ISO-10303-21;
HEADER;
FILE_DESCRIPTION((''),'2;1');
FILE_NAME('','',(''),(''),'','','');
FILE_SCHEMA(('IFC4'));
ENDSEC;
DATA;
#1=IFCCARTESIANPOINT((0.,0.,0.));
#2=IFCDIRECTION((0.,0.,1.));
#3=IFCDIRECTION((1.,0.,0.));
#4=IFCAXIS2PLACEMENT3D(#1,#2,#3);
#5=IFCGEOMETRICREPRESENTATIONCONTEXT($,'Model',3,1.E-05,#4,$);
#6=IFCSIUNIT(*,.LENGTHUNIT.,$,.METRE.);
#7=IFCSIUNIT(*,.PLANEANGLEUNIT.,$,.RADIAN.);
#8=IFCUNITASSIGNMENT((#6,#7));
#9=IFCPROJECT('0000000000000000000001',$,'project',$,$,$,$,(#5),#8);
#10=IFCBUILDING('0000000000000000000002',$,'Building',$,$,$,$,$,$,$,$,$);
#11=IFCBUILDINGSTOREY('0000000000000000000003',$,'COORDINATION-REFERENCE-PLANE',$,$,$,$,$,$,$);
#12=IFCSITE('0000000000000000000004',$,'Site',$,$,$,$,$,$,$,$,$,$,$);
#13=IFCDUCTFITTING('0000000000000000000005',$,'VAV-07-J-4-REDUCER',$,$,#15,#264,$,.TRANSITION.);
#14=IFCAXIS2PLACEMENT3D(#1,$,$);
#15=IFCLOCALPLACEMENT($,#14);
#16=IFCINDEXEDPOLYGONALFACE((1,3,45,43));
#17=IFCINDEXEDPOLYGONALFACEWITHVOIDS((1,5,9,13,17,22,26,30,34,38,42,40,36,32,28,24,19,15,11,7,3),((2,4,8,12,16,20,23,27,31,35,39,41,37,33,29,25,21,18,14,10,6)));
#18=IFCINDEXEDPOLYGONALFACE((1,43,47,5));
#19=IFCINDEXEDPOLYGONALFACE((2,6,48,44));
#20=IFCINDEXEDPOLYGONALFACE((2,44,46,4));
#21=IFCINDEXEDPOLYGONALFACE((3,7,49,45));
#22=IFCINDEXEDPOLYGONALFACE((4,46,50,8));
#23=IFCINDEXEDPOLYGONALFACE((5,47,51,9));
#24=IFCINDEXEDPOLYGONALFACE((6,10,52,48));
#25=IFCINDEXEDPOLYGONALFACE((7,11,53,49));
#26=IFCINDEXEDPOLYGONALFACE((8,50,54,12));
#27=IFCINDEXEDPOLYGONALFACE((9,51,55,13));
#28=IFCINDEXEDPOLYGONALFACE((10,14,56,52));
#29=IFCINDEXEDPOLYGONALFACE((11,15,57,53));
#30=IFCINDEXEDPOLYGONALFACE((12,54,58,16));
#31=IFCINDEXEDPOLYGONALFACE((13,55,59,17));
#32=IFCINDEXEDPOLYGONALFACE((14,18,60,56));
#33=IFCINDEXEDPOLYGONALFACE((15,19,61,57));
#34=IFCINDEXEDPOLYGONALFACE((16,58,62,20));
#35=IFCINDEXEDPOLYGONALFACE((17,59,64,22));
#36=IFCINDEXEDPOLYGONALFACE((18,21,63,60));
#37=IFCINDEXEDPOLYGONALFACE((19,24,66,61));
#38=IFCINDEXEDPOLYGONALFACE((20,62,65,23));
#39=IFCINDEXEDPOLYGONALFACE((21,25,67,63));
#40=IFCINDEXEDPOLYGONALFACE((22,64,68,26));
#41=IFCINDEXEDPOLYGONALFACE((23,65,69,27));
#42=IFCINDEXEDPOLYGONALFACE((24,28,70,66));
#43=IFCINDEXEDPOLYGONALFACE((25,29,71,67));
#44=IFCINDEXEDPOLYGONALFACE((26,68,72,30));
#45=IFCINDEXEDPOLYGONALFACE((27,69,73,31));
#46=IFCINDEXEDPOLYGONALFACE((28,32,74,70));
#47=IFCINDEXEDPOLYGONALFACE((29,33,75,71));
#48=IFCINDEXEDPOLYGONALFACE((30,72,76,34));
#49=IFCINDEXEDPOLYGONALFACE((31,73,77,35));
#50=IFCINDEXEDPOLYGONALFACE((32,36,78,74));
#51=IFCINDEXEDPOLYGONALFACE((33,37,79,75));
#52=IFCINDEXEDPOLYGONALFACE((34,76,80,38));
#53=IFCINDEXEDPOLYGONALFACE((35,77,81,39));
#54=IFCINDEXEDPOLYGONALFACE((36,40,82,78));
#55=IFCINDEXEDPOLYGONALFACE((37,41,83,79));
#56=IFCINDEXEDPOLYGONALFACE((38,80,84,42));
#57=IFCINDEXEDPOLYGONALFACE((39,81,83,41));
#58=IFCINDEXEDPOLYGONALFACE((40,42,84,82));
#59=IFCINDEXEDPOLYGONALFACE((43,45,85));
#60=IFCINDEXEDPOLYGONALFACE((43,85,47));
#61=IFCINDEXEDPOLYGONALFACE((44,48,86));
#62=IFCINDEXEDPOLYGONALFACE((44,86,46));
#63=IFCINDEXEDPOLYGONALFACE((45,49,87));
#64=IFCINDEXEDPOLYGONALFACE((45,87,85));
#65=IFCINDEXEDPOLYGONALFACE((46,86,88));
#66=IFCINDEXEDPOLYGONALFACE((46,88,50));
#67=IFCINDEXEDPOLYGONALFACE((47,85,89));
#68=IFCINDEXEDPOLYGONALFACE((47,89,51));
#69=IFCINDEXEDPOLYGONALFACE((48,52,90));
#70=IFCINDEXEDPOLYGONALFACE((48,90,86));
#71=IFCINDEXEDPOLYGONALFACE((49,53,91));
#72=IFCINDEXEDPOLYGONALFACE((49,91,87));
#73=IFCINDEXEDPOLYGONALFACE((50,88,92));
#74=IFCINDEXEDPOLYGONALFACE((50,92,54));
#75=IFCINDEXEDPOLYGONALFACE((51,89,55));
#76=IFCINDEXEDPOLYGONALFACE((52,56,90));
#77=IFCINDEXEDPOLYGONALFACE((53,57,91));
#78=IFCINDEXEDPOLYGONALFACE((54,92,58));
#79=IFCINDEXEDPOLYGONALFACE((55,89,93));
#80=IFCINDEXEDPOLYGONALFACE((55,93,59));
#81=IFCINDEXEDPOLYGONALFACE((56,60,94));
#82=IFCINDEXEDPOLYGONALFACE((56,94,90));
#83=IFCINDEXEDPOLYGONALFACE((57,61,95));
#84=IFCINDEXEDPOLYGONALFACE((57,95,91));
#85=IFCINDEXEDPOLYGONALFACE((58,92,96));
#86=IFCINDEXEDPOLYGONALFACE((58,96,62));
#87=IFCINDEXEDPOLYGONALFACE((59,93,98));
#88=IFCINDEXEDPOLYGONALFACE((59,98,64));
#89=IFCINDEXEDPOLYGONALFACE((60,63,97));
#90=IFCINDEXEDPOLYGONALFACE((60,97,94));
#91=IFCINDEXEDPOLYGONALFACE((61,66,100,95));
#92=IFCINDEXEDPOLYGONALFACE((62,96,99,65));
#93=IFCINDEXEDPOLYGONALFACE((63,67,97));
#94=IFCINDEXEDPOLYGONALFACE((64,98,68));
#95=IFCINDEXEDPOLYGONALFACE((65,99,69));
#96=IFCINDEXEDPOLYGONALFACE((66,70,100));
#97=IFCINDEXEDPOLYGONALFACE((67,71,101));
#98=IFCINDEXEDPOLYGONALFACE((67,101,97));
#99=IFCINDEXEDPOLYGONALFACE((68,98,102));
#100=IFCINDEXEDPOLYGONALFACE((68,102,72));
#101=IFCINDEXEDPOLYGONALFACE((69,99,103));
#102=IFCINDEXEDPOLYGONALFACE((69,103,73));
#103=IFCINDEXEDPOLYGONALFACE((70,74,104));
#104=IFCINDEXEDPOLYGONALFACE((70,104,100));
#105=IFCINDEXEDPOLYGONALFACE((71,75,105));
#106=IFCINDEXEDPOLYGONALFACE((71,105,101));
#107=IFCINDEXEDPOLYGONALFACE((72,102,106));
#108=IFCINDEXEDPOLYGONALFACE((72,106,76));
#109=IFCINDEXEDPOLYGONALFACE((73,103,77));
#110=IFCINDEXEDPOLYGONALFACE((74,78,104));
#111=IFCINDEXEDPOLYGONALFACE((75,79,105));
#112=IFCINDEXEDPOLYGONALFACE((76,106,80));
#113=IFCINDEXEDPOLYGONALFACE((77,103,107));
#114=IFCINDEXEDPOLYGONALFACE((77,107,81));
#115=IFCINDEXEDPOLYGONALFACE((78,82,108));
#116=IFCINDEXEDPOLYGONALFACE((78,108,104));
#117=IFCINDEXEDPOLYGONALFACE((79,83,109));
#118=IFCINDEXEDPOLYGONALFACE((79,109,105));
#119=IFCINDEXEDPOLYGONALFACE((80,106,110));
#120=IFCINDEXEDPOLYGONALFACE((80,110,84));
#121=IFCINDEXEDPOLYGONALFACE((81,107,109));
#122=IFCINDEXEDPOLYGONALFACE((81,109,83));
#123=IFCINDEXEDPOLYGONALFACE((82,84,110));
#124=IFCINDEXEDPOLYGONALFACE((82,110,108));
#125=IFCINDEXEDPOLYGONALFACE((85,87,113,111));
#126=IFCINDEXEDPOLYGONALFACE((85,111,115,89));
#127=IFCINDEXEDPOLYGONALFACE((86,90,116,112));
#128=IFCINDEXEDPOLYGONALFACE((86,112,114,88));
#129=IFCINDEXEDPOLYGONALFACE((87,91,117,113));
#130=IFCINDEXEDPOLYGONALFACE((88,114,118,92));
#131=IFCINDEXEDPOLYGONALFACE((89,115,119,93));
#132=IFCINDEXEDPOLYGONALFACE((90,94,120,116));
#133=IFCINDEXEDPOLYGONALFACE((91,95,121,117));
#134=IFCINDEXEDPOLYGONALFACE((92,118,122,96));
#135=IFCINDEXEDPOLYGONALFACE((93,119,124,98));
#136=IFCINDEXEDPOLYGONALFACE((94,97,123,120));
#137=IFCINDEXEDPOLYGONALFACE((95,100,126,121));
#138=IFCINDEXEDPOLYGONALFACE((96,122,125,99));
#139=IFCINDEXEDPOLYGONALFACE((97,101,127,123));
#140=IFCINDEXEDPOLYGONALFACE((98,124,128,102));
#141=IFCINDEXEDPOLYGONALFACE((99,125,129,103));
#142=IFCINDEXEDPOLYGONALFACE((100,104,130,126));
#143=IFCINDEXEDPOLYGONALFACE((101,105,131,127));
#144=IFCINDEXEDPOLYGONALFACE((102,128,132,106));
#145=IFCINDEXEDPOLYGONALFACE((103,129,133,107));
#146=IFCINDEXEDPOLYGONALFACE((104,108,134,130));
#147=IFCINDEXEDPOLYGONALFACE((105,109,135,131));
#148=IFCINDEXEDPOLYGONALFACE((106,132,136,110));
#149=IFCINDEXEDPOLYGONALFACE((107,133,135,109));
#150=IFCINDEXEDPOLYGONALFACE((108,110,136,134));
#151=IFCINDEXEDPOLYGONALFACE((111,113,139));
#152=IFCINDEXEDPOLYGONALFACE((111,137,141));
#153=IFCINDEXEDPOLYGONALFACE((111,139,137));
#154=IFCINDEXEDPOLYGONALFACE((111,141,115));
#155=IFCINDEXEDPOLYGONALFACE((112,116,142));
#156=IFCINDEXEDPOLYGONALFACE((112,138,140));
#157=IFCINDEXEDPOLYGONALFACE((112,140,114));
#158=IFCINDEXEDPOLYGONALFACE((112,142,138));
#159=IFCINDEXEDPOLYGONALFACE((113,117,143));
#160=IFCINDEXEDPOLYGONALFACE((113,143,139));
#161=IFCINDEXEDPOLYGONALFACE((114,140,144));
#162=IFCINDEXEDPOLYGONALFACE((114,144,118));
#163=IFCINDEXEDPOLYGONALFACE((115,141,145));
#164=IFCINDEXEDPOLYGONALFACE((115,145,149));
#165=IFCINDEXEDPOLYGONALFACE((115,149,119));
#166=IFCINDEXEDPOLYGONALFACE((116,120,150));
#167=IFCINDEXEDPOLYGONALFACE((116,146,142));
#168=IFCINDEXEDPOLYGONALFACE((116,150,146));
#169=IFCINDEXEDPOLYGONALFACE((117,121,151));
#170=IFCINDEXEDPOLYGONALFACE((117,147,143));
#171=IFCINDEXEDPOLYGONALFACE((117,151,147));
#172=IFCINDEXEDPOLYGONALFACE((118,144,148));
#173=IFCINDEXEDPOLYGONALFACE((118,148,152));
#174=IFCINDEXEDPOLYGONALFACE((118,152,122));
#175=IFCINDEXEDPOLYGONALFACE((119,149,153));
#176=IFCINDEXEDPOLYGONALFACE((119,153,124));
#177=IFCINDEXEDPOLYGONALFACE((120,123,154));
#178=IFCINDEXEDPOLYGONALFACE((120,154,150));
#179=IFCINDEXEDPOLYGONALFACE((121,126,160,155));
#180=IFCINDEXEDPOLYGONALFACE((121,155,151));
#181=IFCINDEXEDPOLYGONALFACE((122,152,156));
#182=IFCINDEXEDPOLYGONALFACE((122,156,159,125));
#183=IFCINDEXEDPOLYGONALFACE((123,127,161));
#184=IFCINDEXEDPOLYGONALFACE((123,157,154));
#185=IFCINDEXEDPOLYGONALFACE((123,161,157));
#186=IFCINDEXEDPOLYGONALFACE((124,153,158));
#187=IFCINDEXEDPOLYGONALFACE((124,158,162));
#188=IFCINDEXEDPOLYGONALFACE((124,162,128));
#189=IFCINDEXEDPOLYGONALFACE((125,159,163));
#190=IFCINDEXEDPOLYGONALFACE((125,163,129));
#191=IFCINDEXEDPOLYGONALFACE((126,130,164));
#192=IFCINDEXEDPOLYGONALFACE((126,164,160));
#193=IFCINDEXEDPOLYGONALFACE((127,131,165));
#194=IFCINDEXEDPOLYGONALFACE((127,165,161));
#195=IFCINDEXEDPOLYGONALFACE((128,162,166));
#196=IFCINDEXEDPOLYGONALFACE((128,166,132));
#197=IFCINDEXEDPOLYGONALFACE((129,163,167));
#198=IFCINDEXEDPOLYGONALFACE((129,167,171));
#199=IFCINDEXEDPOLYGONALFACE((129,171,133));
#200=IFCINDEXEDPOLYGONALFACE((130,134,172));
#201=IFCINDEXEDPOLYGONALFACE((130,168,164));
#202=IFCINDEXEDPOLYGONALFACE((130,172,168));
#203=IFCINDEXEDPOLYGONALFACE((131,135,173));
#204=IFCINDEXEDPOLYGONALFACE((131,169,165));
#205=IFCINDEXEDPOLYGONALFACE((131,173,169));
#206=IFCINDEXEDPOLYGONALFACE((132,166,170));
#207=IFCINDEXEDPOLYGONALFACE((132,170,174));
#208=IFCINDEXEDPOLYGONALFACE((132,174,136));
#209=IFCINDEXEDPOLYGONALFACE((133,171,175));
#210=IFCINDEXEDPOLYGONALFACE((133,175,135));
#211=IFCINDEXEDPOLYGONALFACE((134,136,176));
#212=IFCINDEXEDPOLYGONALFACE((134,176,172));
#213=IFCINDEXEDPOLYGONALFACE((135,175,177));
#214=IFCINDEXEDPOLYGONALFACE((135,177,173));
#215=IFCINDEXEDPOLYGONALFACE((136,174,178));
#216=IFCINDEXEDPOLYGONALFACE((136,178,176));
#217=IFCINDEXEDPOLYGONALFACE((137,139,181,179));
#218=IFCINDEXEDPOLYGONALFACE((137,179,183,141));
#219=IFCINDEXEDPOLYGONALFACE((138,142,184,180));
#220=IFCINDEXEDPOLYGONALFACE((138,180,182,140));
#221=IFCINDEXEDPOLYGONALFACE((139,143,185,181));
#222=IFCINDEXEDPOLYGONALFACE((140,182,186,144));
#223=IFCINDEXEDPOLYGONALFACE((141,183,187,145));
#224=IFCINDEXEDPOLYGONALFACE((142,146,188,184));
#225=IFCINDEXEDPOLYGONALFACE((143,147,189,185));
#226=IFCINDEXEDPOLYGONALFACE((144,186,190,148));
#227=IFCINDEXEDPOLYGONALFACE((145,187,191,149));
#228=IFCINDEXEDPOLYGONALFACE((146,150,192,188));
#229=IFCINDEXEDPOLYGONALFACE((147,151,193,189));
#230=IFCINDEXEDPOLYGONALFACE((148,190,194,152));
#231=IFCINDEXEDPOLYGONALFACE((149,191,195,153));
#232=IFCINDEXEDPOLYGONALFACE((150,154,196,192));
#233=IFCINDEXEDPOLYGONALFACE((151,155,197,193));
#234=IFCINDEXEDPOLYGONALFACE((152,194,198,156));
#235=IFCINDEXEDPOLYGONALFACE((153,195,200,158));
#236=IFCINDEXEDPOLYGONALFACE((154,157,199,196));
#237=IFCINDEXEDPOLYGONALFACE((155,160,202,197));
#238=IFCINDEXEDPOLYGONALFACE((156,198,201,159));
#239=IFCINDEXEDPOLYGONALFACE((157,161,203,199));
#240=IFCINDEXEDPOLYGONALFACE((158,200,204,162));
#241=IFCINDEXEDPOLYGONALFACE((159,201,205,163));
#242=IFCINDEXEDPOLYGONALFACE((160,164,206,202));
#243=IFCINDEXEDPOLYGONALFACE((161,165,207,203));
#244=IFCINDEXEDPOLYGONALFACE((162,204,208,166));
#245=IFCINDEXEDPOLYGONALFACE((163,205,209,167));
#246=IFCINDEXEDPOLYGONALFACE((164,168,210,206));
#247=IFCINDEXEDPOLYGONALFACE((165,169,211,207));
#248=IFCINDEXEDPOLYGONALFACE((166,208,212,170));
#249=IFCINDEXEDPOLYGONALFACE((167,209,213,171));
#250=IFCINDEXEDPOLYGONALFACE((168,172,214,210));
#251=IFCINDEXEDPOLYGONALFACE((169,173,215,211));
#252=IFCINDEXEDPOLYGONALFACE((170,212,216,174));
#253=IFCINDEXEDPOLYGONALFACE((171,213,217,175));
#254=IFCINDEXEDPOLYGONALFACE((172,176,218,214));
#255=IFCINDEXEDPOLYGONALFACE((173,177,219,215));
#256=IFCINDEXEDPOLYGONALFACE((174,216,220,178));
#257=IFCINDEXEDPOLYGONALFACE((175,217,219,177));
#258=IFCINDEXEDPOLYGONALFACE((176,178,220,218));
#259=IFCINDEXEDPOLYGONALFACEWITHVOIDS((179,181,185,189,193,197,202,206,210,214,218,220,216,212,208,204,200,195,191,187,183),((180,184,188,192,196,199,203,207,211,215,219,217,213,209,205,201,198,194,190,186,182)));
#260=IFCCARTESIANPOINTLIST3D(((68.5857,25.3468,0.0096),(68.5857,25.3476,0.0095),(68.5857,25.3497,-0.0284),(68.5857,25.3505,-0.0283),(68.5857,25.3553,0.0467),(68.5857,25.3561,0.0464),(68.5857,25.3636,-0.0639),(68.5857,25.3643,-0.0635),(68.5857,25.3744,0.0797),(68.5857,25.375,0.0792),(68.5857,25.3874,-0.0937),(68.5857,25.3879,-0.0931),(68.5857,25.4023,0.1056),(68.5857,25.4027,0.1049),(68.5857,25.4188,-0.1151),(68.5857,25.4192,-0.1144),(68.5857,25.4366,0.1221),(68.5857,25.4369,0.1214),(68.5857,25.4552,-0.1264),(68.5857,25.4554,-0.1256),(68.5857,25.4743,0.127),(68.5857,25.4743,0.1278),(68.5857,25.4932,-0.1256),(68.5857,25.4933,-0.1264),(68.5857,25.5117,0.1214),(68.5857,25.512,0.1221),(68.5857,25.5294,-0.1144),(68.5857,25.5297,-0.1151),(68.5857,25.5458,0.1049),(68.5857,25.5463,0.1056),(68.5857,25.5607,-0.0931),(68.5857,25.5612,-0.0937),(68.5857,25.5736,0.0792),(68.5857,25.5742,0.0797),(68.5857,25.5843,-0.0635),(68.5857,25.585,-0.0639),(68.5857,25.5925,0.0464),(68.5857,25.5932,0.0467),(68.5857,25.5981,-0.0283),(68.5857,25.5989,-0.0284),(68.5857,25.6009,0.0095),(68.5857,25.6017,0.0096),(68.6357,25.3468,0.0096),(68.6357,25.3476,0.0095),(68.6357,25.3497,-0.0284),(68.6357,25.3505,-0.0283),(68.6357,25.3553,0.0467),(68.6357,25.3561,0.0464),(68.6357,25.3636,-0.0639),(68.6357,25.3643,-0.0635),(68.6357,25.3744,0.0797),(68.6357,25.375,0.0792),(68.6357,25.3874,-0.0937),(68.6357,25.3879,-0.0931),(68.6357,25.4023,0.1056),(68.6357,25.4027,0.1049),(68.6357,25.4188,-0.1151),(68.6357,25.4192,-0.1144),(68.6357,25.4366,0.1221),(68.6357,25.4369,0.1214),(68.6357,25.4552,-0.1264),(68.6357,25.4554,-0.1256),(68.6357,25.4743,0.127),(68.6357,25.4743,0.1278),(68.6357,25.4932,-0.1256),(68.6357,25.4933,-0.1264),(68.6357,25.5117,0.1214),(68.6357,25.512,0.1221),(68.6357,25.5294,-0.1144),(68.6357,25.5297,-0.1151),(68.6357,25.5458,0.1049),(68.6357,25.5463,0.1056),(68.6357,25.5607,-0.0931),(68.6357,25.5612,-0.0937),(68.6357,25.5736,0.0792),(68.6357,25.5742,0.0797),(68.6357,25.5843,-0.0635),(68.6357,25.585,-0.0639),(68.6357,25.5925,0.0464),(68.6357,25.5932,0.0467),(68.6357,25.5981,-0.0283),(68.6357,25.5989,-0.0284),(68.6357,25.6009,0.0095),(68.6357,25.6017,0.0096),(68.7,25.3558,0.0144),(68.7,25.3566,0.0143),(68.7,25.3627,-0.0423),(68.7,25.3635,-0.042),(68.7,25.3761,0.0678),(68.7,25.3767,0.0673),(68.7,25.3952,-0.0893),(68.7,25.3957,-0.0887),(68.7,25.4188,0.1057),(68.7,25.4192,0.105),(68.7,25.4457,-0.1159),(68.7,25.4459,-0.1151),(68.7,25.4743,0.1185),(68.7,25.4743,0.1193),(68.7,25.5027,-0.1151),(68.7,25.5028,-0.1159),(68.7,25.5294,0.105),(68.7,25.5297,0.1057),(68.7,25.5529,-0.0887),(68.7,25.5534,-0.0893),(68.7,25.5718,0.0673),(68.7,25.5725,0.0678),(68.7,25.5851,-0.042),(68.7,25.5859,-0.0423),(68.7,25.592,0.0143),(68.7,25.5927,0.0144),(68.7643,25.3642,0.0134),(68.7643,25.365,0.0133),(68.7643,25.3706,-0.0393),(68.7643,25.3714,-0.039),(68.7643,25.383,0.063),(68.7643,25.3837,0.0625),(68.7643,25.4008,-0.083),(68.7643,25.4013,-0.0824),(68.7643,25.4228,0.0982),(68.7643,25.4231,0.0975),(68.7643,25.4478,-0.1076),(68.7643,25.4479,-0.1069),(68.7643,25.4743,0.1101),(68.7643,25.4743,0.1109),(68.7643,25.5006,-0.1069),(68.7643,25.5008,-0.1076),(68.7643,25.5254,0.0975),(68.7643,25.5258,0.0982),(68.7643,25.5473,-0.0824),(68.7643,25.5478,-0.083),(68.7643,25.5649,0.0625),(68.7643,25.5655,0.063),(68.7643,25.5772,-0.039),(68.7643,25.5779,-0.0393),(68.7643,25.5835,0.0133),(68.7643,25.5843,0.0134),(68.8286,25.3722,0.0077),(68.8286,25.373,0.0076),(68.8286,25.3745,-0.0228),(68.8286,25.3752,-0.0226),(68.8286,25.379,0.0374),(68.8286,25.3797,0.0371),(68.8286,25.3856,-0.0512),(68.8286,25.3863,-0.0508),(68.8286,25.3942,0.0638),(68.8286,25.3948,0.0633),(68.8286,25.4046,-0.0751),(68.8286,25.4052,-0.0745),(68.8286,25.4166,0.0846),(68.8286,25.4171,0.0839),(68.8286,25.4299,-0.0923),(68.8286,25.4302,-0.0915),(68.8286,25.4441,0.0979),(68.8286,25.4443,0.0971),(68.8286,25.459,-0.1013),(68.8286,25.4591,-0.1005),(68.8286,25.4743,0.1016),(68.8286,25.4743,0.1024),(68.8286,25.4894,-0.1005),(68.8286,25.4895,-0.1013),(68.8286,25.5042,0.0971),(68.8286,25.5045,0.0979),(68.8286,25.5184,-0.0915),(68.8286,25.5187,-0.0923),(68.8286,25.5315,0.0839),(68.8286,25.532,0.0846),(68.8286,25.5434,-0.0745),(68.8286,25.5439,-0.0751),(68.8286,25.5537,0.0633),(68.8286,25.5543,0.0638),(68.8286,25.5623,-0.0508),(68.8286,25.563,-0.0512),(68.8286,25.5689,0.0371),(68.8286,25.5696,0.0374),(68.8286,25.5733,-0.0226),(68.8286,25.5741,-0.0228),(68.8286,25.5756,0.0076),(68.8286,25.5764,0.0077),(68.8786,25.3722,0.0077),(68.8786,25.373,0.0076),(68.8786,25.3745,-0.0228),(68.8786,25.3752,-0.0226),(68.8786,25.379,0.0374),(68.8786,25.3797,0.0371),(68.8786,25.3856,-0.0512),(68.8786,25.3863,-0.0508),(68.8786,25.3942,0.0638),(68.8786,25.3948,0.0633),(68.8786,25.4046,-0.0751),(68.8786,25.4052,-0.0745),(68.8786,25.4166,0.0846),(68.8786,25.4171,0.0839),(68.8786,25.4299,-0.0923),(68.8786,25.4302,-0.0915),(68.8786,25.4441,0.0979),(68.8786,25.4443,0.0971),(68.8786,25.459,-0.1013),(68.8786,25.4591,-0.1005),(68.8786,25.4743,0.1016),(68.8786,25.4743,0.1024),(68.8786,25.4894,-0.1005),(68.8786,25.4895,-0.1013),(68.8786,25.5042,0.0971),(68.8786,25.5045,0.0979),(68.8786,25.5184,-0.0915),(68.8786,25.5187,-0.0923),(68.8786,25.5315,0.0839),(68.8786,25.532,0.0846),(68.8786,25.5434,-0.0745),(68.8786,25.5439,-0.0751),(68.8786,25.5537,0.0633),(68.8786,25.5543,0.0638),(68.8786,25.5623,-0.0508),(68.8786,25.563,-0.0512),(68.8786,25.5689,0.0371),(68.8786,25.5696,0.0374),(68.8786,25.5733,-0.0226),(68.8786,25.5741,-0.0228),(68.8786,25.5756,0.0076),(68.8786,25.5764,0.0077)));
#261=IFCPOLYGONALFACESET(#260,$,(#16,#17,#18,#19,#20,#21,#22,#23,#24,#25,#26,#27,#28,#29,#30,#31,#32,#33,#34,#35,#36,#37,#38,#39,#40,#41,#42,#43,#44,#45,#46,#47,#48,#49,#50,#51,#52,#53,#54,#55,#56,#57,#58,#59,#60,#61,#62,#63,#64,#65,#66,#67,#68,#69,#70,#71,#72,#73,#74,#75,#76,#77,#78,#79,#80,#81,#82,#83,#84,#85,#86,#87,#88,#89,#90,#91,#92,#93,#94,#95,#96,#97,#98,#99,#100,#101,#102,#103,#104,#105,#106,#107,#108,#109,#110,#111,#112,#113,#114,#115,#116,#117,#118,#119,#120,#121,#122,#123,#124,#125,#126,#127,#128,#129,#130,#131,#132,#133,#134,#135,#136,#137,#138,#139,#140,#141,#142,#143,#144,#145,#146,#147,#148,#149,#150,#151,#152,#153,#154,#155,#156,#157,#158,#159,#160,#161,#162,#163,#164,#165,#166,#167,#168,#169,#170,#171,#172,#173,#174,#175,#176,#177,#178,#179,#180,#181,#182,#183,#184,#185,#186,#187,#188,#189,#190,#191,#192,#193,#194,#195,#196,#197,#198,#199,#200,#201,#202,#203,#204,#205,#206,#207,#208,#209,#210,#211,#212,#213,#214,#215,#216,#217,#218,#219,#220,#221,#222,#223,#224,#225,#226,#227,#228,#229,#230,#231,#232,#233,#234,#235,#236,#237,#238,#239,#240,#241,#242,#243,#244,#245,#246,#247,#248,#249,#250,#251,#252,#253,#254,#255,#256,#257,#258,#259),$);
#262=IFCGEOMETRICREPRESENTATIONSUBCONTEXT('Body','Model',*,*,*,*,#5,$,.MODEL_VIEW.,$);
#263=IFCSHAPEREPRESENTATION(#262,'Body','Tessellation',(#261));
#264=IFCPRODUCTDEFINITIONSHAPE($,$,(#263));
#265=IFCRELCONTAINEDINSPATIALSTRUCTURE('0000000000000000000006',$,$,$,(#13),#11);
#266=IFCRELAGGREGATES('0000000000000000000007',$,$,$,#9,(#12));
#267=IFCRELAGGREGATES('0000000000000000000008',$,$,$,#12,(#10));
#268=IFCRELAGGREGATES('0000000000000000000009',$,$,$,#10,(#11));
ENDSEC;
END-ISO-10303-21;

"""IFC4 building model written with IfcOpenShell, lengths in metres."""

from ifc_helpers import new_model, entity, si_unit, frame, origin_with_axes, place, context, subcontext, project, spatial, element, save


model = new_model("IFC4")

# Units and contexts
model_context = context("Model", 3, precision=1e-05, world=origin_with_axes())
body_context_1 = subcontext(model_context, "Body", "Model", "MODEL_VIEW")
ifc_project = project(units=[si_unit("LENGTHUNIT", "METRE"), si_unit("PLANEANGLEUNIT", "RADIAN")], contexts=[model_context])

# Site, building, storey
site = spatial("IfcSite", under=ifc_project, Name="Site")
building = spatial("IfcBuilding", under=site, Name="Building")
storey = spatial("IfcBuildingStorey", under=building, Name="COORDINATION-REFERENCE-PLANE")

# Duct fitting
for number, where, z_axis, x_axis, name in (
    (1, (68.5857, 25.4743, 0.0), (0.0, 1.0, 0.0), (0.0, 0.0, 1.0), "VAV-07-J-4-REDUCER"),
):
    element("IfcDuctFitting", number, at=place(None, frame(where, z_axis=z_axis, x_axis=x_axis)), inside=storey, Name=name, PredefinedType="TRANSITION", context=body_context_1, shape_type="SweptSolid", body=[
        entity("IfcRevolvedAreaSolid", entity("IfcArbitraryClosedProfileDef", "AREA", None, entity("IfcPolyline", [entity("IfcCartesianPoint", [0.1278, 0.0]), entity("IfcCartesianPoint", [0.1278, 0.05]), entity("IfcCartesianPoint", [0.1024, 0.2429]), entity("IfcCartesianPoint", [0.1024, 0.2929]), entity("IfcCartesianPoint", [0.1016, 0.2929]), entity("IfcCartesianPoint", [0.1016, 0.2429]), entity("IfcCartesianPoint", [0.127, 0.05]), entity("IfcCartesianPoint", [0.127, 0.0]), entity("IfcCartesianPoint", [0.1278, 0.0])])), entity("IfcAxis2Placement3D", entity("IfcCartesianPoint", [0.0, 0.0, 0.0])), entity("IfcAxis1Placement", entity("IfcCartesianPoint", [0.0, 0.0, 0.0]), entity("IfcDirection", [0.0, 1.0, 0.0])), 6.283185),
    ])

save(model, "model.ifc")
